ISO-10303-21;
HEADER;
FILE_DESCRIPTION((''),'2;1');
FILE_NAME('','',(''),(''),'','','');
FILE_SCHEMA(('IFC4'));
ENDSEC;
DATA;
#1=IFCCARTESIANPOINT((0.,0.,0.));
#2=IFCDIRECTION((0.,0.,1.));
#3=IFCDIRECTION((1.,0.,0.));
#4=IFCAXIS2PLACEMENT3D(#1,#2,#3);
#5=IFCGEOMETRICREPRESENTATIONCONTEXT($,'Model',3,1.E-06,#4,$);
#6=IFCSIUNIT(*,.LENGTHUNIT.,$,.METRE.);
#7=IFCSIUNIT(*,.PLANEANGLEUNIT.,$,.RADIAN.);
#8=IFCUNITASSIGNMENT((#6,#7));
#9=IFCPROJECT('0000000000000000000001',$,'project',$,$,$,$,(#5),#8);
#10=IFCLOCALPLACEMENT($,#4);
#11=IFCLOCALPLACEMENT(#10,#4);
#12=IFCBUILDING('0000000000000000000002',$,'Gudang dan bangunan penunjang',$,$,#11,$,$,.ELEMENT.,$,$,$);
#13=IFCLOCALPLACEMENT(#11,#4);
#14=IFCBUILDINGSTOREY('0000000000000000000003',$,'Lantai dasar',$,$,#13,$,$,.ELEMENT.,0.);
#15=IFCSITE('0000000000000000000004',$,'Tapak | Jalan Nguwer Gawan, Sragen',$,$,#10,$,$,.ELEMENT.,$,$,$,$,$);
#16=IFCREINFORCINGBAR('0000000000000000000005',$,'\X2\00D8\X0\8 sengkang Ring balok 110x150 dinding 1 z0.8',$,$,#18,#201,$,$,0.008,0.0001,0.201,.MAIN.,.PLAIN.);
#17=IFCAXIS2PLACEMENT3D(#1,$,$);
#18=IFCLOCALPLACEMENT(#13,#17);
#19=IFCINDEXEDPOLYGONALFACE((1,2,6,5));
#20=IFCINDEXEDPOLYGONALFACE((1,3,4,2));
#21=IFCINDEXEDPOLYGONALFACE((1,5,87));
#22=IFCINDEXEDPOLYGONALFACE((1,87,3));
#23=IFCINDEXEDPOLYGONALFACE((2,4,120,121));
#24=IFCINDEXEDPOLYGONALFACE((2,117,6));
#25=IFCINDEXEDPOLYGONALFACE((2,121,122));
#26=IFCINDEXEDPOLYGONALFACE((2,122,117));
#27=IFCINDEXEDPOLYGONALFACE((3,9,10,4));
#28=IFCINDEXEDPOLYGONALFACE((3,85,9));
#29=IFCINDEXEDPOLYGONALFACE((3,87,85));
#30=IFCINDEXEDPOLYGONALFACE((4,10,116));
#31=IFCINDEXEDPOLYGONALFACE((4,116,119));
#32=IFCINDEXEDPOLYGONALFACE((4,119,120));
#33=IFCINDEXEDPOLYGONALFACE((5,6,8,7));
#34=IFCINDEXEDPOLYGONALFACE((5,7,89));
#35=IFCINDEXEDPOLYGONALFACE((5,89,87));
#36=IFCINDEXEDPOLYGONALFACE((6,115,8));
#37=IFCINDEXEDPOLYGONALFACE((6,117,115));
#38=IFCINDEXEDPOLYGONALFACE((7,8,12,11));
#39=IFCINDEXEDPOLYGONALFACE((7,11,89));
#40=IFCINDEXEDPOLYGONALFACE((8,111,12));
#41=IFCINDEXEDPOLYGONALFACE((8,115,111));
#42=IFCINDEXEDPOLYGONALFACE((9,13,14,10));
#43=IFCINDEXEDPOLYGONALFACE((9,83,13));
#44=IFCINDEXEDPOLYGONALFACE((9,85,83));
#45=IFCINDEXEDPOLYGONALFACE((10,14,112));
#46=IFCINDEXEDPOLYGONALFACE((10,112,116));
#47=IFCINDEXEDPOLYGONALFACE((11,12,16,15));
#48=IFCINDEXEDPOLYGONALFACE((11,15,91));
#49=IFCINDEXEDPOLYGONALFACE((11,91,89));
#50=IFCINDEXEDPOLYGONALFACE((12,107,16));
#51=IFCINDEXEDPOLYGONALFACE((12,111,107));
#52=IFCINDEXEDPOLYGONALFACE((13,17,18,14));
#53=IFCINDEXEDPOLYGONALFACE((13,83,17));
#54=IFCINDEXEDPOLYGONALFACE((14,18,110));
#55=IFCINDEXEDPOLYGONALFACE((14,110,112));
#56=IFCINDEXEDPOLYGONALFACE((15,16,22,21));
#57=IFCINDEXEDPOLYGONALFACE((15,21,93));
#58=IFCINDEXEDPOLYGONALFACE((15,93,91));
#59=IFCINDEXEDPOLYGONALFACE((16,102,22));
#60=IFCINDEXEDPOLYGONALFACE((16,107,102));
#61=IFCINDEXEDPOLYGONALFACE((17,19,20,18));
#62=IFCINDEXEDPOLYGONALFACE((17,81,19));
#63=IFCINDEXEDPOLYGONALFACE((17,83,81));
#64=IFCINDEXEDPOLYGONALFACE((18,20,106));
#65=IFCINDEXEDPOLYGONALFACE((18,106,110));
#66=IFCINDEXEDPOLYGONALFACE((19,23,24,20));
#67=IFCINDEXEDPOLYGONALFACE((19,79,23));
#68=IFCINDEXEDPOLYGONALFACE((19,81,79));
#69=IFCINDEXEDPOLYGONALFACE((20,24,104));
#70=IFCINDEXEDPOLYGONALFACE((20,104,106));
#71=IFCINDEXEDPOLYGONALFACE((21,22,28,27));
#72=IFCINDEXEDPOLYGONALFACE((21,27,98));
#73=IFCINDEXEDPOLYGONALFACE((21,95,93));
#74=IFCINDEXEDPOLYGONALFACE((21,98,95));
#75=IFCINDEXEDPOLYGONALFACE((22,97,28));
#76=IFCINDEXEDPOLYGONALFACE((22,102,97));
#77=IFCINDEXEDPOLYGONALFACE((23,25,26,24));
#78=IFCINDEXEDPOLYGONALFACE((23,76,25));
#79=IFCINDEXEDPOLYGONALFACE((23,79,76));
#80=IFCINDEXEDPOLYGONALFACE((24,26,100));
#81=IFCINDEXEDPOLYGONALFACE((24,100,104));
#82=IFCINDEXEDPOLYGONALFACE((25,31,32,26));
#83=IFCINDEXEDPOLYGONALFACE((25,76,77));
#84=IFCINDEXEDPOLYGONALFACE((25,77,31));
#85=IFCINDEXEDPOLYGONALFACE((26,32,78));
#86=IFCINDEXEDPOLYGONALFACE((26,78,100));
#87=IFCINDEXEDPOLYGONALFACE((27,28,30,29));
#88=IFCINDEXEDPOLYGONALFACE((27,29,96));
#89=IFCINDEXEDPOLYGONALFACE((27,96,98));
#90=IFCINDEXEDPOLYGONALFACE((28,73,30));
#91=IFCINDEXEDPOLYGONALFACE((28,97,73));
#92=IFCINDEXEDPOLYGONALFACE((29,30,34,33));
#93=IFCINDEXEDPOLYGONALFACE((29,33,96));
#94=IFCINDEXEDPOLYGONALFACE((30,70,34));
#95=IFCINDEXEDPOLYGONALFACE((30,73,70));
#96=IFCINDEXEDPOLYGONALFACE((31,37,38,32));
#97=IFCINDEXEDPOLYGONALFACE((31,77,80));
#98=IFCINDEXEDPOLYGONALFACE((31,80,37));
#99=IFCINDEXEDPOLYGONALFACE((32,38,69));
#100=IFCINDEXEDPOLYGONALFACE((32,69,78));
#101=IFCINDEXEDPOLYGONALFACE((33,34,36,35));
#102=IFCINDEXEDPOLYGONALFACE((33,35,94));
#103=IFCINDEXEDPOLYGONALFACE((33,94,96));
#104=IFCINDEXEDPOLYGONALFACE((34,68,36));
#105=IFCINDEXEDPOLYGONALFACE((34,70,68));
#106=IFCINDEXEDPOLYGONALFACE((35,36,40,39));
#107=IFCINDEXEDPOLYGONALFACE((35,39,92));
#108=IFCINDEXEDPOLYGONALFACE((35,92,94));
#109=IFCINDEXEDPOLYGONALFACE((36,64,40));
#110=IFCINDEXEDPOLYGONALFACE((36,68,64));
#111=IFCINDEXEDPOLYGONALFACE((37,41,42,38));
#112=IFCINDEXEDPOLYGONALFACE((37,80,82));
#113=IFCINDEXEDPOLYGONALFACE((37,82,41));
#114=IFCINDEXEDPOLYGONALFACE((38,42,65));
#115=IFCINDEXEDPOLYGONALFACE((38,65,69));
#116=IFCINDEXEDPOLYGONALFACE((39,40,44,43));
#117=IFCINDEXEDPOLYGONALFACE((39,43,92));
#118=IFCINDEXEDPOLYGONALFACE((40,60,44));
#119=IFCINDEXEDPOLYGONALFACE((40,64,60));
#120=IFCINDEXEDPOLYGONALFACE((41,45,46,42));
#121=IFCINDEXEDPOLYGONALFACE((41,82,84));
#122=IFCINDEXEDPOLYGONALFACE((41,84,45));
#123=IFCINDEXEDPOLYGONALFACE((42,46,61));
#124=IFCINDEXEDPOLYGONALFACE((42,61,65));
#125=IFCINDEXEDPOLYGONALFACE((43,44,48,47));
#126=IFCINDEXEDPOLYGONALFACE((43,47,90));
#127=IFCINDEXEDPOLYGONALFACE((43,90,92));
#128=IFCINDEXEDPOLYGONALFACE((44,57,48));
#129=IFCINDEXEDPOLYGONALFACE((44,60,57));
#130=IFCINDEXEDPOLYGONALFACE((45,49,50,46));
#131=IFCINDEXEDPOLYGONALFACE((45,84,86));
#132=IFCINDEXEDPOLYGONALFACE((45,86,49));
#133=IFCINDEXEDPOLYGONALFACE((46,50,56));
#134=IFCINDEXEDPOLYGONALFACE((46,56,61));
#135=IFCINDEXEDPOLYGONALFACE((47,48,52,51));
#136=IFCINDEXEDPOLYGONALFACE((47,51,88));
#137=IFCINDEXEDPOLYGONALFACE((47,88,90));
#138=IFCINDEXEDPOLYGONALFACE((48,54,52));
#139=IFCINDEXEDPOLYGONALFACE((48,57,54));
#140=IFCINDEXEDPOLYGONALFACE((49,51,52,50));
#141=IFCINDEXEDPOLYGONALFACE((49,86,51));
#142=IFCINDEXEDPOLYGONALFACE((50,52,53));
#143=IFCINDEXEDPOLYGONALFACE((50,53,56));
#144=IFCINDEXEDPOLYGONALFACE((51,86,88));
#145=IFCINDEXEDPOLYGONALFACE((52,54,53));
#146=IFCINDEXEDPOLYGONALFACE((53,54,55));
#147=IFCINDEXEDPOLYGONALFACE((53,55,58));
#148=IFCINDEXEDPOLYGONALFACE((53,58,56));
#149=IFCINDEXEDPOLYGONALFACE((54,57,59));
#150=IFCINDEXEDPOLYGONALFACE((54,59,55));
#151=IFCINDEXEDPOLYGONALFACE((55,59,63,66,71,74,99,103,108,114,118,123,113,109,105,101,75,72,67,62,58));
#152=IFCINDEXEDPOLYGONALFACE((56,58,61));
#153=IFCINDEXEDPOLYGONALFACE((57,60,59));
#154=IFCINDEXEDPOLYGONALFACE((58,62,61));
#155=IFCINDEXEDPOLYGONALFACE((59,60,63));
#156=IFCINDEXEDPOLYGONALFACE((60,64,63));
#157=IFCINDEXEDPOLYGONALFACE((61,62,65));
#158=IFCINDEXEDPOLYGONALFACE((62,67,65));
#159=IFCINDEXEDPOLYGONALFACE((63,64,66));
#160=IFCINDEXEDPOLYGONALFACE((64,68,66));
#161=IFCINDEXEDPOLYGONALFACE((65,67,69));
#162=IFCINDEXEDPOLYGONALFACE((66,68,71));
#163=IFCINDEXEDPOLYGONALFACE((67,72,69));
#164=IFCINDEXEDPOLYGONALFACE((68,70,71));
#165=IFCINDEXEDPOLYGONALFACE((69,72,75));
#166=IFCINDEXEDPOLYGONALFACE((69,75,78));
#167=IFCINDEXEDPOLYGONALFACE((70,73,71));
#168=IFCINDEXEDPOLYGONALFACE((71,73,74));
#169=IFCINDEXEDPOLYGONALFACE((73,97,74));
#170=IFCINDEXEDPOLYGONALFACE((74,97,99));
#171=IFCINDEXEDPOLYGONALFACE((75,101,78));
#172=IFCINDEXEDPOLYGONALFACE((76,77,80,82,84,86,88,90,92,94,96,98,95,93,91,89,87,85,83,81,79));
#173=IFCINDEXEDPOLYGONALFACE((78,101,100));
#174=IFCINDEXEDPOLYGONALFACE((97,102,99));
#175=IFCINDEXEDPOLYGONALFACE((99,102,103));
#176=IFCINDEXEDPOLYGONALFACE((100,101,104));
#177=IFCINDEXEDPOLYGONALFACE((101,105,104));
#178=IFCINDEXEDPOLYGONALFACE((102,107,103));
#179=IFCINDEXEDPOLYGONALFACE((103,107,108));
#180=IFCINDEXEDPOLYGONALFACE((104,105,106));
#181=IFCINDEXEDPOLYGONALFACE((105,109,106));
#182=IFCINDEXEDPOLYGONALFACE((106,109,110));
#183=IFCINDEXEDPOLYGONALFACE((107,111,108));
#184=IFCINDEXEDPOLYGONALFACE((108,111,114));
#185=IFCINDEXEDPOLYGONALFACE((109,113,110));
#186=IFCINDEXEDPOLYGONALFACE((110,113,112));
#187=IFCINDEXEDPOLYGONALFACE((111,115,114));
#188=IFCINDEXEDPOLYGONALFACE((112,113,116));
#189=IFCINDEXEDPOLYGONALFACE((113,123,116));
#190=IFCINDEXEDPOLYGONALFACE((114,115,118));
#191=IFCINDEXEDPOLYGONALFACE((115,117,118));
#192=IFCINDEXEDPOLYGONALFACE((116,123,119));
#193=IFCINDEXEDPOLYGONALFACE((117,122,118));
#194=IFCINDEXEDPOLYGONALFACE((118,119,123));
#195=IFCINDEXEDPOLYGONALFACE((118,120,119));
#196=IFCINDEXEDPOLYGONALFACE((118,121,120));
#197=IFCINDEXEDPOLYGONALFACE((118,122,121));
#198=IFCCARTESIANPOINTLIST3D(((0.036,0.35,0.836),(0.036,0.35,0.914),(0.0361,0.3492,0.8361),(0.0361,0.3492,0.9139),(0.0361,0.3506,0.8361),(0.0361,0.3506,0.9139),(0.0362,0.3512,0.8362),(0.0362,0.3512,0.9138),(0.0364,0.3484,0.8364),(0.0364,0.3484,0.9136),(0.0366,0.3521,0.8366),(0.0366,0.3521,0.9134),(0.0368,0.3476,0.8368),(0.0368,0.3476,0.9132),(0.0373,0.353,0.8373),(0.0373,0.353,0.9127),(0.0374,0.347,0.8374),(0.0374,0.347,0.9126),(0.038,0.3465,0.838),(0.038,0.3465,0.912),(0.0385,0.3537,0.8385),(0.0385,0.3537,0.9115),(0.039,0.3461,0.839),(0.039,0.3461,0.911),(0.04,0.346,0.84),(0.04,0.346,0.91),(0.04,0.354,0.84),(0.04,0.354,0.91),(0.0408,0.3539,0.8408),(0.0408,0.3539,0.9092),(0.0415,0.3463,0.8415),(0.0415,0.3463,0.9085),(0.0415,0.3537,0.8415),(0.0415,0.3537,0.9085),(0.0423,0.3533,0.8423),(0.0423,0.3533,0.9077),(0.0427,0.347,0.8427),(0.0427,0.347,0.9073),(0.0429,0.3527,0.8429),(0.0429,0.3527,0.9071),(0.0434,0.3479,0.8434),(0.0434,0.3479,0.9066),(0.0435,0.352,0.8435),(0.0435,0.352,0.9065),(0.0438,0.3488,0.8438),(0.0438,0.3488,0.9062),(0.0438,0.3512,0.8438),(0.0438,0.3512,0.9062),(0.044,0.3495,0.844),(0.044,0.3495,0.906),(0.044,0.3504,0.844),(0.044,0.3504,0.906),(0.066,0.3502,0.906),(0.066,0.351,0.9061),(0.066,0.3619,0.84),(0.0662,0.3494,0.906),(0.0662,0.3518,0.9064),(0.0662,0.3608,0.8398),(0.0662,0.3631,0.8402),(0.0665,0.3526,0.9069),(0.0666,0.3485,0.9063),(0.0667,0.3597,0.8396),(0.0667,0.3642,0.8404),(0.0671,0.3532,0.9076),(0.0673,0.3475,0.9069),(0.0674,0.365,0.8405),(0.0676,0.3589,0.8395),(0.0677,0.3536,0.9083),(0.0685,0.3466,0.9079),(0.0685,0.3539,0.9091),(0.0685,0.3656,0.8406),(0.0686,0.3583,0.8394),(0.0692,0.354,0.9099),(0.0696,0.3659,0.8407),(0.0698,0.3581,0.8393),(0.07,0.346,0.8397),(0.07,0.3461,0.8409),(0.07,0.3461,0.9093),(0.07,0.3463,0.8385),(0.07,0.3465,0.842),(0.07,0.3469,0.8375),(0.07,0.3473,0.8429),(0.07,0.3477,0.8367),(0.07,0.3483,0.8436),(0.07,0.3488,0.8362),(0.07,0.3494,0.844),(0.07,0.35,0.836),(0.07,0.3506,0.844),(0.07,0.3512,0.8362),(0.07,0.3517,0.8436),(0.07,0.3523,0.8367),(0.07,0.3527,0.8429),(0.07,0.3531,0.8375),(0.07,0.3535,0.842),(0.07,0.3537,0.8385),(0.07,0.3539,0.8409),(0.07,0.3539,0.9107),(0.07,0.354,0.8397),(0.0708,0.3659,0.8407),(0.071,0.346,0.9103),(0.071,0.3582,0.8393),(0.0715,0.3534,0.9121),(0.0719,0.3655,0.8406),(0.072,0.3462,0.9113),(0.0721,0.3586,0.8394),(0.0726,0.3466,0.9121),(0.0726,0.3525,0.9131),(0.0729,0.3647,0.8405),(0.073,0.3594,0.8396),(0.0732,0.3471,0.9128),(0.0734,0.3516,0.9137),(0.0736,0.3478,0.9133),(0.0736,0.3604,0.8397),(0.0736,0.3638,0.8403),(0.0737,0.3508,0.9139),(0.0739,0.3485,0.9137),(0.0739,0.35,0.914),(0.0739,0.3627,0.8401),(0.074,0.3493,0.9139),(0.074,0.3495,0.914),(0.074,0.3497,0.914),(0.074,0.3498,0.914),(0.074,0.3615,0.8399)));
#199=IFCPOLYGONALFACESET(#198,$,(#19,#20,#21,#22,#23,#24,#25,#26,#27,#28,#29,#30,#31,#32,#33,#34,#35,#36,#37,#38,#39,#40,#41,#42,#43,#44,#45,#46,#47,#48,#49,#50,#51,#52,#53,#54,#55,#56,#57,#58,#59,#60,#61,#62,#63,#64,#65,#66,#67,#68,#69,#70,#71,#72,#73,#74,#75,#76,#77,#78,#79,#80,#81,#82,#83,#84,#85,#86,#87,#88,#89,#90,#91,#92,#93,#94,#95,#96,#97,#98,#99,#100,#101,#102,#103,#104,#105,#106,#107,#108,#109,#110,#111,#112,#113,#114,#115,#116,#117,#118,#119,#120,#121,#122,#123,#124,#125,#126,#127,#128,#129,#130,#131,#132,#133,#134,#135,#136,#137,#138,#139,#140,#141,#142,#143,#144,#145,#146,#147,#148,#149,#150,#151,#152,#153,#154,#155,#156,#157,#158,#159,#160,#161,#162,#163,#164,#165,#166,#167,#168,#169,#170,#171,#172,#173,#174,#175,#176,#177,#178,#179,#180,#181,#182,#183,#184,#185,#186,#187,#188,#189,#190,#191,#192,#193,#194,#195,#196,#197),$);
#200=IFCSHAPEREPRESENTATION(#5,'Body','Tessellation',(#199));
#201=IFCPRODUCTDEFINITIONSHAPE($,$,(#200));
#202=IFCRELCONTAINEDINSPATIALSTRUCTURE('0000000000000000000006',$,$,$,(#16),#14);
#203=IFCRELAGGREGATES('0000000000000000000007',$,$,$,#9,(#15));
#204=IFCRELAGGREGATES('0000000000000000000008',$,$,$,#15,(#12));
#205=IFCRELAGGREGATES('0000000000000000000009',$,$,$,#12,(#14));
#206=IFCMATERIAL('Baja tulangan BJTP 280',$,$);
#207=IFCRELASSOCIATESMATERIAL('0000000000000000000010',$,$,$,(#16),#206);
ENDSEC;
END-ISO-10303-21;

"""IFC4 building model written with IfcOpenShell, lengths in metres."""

from ifc_helpers import new_model, entity, si_unit, origin_with_axes, place, context, project, spatial, material, element, save


model = new_model("IFC4")

# Units and contexts
model_context = context("Model", 3, precision=1e-06, world=origin_with_axes())
ifc_project = project(units=[si_unit("LENGTHUNIT", "METRE"), si_unit("PLANEANGLEUNIT", "RADIAN")], contexts=[model_context])

# Site, building, storey
site_placement = place(None, origin_with_axes())
site = spatial("IfcSite", under=ifc_project, at=site_placement, Name="Tapak | Jalan Nguwer Gawan, Sragen", CompositionType="ELEMENT")
building_placement = place(site_placement, origin_with_axes())
building = spatial("IfcBuilding", under=site, at=building_placement, Name="Gudang dan bangunan penunjang", CompositionType="ELEMENT")
storey_placement = place(building_placement, origin_with_axes())
storey = spatial("IfcBuildingStorey", under=building, at=storey_placement, Name="Lantai dasar", CompositionType="ELEMENT", Elevation=0.0)

# Shared definitions
placement = place(None, origin_with_axes())

# Reinforcing bar
ifc_material_1 = material(Name="Baja tulangan BJTP 280")
element("IfcReinforcingBar", 1, at=placement, inside=storey, material=ifc_material_1, Name="Ø8 sengkang Ring balok 110x150 dinding 1 z0.8", BarLength=0.201, BarSurface="PLAIN", CrossSectionArea=0.0001, NominalDiameter=0.008, PredefinedType="MAIN", context=model_context, shape_type="AdvancedSweptSolid", body=[
    entity("IfcSweptDiskSolid", entity("IfcPolyline", [entity("IfcCartesianPoint", [0.07, 0.35, 0.84]), entity("IfcCartesianPoint", [0.04, 0.35, 0.84]), entity("IfcCartesianPoint", [0.04, 0.35, 0.91]), entity("IfcCartesianPoint", [0.07, 0.35, 0.91]), entity("IfcCartesianPoint", [0.07, 0.362, 0.84])]), 0.004),
])

save(model, "model.ifc")
